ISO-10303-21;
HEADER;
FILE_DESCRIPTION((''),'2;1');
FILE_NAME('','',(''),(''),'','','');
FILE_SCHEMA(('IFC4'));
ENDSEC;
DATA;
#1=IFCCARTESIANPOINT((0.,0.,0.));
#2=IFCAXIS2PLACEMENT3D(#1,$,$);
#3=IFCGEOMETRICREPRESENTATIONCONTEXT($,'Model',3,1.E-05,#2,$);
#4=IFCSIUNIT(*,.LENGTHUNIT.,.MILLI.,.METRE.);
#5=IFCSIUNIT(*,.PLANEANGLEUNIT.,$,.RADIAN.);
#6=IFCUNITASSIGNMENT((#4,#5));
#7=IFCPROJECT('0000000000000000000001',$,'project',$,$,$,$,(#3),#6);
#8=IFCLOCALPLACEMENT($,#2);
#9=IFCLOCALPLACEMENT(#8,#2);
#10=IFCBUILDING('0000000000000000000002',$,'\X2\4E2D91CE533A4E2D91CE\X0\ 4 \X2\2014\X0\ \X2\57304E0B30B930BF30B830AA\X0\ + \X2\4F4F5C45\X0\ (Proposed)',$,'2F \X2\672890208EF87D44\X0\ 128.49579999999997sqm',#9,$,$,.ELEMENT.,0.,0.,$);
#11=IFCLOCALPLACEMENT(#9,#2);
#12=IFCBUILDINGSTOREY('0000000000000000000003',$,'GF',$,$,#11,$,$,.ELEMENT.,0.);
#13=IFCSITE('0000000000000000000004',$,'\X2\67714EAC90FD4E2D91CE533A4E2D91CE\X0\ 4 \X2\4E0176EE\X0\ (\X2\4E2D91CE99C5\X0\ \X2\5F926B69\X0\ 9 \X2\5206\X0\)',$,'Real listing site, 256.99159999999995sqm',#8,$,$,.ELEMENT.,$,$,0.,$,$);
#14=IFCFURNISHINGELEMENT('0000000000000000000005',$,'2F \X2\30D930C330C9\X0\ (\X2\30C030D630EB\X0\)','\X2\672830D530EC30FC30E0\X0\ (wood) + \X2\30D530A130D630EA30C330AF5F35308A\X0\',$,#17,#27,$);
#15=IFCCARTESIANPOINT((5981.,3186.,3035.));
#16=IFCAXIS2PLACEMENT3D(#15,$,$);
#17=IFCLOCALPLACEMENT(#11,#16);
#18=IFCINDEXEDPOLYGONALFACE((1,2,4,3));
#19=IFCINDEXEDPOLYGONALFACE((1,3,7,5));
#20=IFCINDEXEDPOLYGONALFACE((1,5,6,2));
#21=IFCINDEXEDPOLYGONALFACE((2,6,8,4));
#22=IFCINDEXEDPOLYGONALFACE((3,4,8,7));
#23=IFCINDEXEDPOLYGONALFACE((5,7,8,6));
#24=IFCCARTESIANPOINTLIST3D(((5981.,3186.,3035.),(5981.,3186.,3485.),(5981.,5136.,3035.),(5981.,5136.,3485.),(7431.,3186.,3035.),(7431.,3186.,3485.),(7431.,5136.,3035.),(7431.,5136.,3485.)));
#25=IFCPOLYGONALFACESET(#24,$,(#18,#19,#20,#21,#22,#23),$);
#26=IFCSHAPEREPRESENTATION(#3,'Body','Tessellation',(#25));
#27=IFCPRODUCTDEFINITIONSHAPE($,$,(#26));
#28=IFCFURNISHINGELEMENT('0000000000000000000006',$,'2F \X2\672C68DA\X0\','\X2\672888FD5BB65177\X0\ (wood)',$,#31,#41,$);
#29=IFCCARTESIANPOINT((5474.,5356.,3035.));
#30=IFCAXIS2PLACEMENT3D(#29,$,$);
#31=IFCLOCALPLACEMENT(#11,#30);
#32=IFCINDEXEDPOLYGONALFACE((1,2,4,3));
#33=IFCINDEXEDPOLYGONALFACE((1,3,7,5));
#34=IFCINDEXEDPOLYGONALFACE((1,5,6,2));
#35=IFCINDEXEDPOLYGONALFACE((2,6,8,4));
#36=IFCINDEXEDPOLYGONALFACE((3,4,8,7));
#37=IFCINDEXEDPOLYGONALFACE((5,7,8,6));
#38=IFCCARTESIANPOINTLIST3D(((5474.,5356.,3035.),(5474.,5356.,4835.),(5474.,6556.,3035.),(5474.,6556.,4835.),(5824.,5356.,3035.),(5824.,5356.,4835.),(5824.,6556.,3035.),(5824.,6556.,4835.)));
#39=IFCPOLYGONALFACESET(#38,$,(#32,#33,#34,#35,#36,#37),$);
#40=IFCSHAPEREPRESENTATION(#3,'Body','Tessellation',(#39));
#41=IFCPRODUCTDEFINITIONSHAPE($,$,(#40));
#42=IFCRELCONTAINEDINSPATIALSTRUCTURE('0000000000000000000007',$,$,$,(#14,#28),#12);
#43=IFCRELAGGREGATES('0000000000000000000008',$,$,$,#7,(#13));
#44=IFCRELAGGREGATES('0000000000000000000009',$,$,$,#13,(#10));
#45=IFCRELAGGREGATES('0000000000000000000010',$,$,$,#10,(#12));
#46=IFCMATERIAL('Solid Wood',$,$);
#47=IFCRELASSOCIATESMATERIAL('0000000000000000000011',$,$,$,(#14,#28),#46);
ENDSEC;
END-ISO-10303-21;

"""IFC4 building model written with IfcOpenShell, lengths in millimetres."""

from ifc_helpers import new_model, si_unit, frame, frame_2d, origin, place, context, project, spatial, rectangle, extrude, material, element, save


model = new_model("IFC4")

# Units and contexts
model_context = context("Model", 3, precision=1e-05, world=origin())
ifc_project = project(units=[si_unit("LENGTHUNIT", "METRE", prefix="MILLI"), si_unit("PLANEANGLEUNIT", "RADIAN")], contexts=[model_context])

# Site, building, storey
site_placement = place(None, origin())
site = spatial("IfcSite", under=ifc_project, at=site_placement, Name="東京都中野区中野 4 丁目 (中野駅 徒歩 9 分)", ObjectType="Real listing site, 256.99159999999995sqm", CompositionType="ELEMENT", RefElevation=0.0)
building_placement = place(site_placement, origin())
building = spatial("IfcBuilding", under=site, at=building_placement, Name="中野区中野 4 — 地下スタジオ + 住居 (Proposed)", ObjectType="2F 木造軸組 128.49579999999997sqm", CompositionType="ELEMENT", ElevationOfRefHeight=0.0, ElevationOfTerrain=0.0)
storey_placement = place(building_placement, origin())
storey = spatial("IfcBuildingStorey", under=building, at=storey_placement, Name="GF", CompositionType="ELEMENT", Elevation=0.0)

# Shared definitions
ifc_material_1 = material(Name="Solid Wood")

# Furnishing elements
furnishing_1_placement = place(storey_placement, frame((5981.0, 3186.0, 3035.0)))
element("IfcFurnishingElement", 1, at=furnishing_1_placement, inside=storey, material=ifc_material_1, Name="2F ベッド (ダブル)", Description="木フレーム (wood) + ファブリック張り", context=model_context, shape_type="SweptSolid", body=[
    extrude(rectangle(XDim=1450.0, YDim=1950.0, at=frame_2d((725.0, 975.0))), frame((5981.0, 3186.0, 3035.0)), (0.0, 0.0, 1.0), 450.0),
])
furnishing_2_placement = place(storey_placement, frame((5474.0, 5356.0, 3035.0)))
element("IfcFurnishingElement", 2, at=furnishing_2_placement, inside=storey, material=ifc_material_1, Name="2F 本棚", Description="木製家具 (wood)", context=model_context, shape_type="SweptSolid", body=[
    extrude(rectangle(XDim=350.0, YDim=1200.0, at=frame_2d((175.0, 600.0))), frame((5474.0, 5356.0, 3035.0)), (0.0, 0.0, 1.0), 1800.0),
])

save(model, "model.ifc")
